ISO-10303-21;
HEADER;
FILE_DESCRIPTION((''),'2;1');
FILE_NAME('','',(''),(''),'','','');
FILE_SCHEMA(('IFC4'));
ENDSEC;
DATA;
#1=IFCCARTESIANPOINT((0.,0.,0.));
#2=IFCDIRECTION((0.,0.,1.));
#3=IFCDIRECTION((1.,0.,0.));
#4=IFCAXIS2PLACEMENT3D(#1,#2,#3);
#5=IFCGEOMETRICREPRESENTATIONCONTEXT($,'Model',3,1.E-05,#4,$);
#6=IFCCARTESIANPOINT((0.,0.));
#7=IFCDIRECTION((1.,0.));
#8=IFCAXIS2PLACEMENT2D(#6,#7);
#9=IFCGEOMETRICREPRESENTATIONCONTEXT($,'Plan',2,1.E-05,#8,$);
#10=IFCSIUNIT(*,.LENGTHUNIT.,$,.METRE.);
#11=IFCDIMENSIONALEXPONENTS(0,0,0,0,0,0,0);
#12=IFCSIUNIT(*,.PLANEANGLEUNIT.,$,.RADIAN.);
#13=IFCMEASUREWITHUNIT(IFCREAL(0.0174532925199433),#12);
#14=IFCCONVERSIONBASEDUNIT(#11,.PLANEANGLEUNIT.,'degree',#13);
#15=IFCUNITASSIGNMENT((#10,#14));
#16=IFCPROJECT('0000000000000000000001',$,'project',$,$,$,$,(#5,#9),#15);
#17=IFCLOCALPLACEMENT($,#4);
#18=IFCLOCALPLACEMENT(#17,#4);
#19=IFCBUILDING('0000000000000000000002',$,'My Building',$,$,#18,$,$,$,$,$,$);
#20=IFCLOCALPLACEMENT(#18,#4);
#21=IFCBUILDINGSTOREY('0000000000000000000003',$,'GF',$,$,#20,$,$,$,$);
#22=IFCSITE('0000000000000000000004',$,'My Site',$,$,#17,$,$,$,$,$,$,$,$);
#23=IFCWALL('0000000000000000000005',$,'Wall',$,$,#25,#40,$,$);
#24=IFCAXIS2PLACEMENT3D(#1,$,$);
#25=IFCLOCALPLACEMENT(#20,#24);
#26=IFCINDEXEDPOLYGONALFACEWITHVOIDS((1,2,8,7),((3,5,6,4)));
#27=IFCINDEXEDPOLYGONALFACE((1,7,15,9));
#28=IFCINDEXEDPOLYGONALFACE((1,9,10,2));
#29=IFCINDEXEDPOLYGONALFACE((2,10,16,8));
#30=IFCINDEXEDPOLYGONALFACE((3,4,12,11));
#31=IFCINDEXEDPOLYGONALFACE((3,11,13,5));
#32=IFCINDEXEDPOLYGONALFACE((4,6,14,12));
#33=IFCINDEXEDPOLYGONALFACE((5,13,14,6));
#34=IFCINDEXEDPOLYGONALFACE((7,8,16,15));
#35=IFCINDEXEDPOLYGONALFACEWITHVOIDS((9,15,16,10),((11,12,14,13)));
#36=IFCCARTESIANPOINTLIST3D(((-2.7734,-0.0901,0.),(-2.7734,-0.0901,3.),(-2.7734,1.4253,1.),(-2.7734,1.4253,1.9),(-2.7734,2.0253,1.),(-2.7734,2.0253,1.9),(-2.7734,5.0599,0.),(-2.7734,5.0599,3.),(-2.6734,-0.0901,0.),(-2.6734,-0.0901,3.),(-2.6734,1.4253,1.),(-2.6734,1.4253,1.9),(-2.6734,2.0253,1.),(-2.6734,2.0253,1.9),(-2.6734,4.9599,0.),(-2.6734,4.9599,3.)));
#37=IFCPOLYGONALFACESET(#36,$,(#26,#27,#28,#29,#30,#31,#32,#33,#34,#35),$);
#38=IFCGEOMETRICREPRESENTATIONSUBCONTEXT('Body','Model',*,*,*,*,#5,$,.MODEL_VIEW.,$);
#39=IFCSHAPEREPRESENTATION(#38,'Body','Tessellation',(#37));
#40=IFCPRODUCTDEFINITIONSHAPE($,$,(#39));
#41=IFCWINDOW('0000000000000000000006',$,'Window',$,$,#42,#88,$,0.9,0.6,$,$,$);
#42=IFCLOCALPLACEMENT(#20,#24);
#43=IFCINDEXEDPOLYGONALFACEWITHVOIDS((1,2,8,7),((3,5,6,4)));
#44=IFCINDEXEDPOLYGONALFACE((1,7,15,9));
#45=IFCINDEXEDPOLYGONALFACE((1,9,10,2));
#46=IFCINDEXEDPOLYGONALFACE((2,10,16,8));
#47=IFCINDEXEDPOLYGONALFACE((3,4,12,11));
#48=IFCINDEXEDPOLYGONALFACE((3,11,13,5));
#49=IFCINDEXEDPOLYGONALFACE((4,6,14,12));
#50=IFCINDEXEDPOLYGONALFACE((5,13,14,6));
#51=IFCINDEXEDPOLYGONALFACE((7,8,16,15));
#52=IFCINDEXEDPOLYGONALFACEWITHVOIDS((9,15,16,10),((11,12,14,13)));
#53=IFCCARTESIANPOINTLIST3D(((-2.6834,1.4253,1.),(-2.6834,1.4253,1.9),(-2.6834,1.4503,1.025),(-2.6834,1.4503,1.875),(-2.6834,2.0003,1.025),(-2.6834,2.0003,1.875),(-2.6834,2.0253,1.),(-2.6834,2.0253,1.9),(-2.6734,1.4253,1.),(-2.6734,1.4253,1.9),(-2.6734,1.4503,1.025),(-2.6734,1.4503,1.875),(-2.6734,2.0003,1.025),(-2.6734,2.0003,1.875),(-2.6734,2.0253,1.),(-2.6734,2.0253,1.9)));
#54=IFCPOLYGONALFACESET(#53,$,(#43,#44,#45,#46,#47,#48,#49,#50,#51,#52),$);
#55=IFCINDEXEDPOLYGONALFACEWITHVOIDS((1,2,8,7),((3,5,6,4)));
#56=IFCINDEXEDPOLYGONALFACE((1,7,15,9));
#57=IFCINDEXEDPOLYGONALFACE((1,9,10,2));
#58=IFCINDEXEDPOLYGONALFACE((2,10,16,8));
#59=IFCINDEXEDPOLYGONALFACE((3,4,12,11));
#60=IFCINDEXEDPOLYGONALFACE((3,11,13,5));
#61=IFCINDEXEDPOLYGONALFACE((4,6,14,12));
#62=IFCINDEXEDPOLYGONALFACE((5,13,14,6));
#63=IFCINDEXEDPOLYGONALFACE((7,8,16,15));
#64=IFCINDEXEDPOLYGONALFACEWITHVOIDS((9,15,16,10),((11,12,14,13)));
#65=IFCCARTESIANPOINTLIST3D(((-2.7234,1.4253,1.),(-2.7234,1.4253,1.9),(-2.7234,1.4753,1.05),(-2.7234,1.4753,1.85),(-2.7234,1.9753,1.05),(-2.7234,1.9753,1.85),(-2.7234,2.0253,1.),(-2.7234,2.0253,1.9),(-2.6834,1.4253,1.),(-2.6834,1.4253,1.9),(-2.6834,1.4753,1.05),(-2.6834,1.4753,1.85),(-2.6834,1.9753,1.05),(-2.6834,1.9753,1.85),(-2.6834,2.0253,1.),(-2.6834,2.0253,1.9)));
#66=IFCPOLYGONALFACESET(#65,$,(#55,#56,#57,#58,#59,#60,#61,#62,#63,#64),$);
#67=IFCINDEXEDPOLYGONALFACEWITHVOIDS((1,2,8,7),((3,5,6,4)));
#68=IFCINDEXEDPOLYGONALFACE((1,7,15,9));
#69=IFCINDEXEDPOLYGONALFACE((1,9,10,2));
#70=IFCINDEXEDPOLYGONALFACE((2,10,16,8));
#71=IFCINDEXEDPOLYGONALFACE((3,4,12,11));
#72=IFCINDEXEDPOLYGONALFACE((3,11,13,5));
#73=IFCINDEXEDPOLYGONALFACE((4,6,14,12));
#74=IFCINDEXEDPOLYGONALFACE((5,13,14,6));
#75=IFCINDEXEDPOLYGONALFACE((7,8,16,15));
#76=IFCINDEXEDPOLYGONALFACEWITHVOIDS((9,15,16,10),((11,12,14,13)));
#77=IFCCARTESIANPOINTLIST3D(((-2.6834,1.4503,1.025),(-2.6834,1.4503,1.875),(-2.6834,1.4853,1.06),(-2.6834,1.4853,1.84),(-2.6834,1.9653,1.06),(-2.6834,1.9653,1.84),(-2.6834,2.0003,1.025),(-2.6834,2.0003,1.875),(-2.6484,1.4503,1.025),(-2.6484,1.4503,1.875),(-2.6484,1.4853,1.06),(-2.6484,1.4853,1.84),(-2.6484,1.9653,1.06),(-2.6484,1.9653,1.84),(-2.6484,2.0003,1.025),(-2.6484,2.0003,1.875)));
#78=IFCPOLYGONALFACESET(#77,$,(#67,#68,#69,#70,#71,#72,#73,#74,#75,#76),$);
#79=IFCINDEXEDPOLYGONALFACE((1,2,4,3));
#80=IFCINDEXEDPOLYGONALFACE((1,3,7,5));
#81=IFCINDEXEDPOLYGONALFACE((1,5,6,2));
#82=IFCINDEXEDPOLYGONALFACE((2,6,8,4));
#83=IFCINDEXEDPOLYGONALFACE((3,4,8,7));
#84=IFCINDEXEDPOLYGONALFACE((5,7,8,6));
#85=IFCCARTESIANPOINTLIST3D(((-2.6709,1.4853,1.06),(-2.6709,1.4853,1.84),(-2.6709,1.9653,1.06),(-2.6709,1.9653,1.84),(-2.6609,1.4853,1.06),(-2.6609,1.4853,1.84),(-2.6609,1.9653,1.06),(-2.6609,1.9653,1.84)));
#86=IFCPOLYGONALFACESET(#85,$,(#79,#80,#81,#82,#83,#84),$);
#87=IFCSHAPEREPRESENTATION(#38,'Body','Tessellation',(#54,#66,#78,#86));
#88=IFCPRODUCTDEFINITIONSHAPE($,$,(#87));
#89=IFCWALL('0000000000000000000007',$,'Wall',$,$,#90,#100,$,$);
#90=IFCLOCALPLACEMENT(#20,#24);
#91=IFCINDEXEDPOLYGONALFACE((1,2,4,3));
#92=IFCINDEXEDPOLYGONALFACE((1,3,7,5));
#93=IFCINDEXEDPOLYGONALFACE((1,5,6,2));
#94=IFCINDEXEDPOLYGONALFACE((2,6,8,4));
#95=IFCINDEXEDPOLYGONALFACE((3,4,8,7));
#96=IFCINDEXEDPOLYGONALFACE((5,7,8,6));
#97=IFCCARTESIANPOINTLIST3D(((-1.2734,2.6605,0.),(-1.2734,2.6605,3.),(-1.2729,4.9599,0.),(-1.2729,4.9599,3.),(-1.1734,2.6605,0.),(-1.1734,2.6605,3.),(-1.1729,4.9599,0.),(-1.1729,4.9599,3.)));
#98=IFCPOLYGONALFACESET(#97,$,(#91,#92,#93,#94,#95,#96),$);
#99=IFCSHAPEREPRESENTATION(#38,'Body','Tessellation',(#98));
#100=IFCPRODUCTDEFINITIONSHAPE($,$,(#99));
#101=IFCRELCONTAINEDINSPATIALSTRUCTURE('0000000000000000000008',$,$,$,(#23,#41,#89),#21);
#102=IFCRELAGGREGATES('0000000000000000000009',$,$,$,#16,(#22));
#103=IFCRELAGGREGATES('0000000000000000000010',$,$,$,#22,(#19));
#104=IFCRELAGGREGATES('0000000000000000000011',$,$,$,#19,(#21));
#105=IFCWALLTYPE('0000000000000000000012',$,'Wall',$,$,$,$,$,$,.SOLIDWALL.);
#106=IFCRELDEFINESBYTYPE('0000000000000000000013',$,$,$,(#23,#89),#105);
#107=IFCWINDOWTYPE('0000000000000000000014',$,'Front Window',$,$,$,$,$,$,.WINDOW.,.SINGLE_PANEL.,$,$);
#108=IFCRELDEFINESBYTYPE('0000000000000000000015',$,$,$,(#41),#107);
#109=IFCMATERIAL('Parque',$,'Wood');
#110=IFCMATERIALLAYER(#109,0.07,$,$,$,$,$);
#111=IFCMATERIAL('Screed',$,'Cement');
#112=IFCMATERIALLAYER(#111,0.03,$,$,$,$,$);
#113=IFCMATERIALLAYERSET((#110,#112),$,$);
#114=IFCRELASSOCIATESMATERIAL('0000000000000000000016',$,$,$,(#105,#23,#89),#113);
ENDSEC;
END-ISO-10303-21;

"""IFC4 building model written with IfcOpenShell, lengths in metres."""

from ifc_helpers import new_model, entity, si_unit, converted_unit, frame, origin_with_axes, origin_2d_with_axis, place, context, subcontext, project, spatial, line, indexed_curve, outline, extrude, shape, source, transform, mapped, material, layer, layer_set, layer_usage, type_object, type_shapes, element, fill, save


model = new_model("IFC4")

# Units and contexts
model_context = context("Model", 3, precision=1e-05, world=origin_with_axes())
plan_context = context("Plan", 2, precision=1e-05, world=origin_2d_with_axis())
body_context_1 = subcontext(model_context, "Body", "Model", "MODEL_VIEW")
body_context_2 = subcontext(plan_context, "Body", "Plan", "PLAN_VIEW")
ifc_project = project(units=[si_unit("LENGTHUNIT", "METRE"), converted_unit("PLANEANGLEUNIT", "degree", entity("IfcReal", 0.0174532925199433), si_unit("PLANEANGLEUNIT", "RADIAN"), dimensions=[0, 0, 0, 0, 0, 0, 0])], contexts=[model_context, plan_context])

# Site, building, storey
site_placement = place(None, origin_with_axes())
site = spatial("IfcSite", under=ifc_project, at=site_placement, Name="My Site")
building_placement = place(site_placement, origin_with_axes())
building = spatial("IfcBuilding", under=site, at=building_placement, Name="My Building")
storey_placement = place(building_placement, origin_with_axes())
storey = spatial("IfcBuildingStorey", under=building, at=storey_placement, Name="GF")

# Shared definitions
ifc_material_1 = material(Name="Parque", Category="Wood")
ifc_layer_1 = layer(ifc_material_1, 0.07)
ifc_material_2 = material(Name="Screed", Category="Cement")
ifc_layer_2 = layer(ifc_material_2, 0.03)
ifc_layer_set_1 = layer_set([ifc_layer_1, ifc_layer_2])
wall_type = type_object("IfcWallType", Name="Wall", PredefinedType="SOLIDWALL", material=ifc_layer_set_1)

# Wall, opening, window
ifc_layer_usage_1 = layer_usage(ifc_layer_set_1, "AXIS2", "POSITIVE", 0.0)
wall_1_placement = place(storey_placement, frame((-2.7734, 5.0599, 0.0), z_axis=(0.0, 0.0, 1.0), x_axis=(0.0, -1.0, 0.0)))
wall_1 = element("IfcWall", 1, at=wall_1_placement, inside=storey, type_object=wall_type, material=ifc_layer_usage_1, Name="Wall", context=body_context_1, shape_type="SweptSolid", body=[
    extrude(outline(indexed_curve([(0.0, 0.0), (0.1, 0.1), (5.15, 0.1), (5.15, 0.0)], segments=[line(1, 2, 3, 4, 1)])), origin_with_axes(), (0.0, 0.0, 1.0), 3.0),
])
shared_shape_1 = source(origin_with_axes(), body_context_1, "Body", "SweptSolid", [
    extrude(outline(indexed_curve([(0.0, 0.0), (0.6, 0.0), (0.6, 0.9), (0.0, 0.9)], segments=[line(1, 2, 3, 4, 1)])), frame((0.0, -0.6, 0.0), z_axis=(0.0, -1.0, 0.0), x_axis=(1.0, 0.0, 0.0)), (0.0, 0.0, -1.0), 1.2),
])
opening_1_placement = place(wall_1_placement, frame((3.0346, 0.0, 1.0), z_axis=(0.0, 0.0, 1.0), x_axis=(1.0, 0.0, 0.0)))
opening_1 = element("IfcOpeningElement", 2, at=opening_1_placement, cuts=wall_1, PredefinedType="OPENING", context=body_context_1, shape_type="MappedRepresentation", body=[
    mapped(shared_shape_1, transform((0.0, 0.0, 0.0), x_axis=(1.0, 0.0, 0.0), y_axis=(0.0, 1.0, 0.0), z_axis=(0.0, 0.0, 1.0), scale=1.0)),
])
window_type_1 = type_object("IfcWindowType", Name="Front Window", PartitioningType="SINGLE_PANEL", PredefinedType="WINDOW")
shared_shape_2 = source(origin_with_axes(), body_context_1, "Body", "SweptSolid", [
    extrude(outline(indexed_curve([(0.0, 0.0), (0.6, 0.0), (0.6, 0.9), (0.0, 0.9)], segments=[line(1, 2, 3, 4, 1)]), holes=[indexed_curve([(0.025, 0.025), (0.575, 0.025), (0.575, 0.875), (0.025, 0.875)], segments=[line(1, 2, 3, 4, 1)])]), frame((0.0, 0.09, 0.0), z_axis=(0.0, -1.0, 0.0), x_axis=(1.0, 0.0, 0.0)), (0.0, 0.0, -1.0), 0.01),
    extrude(outline(indexed_curve([(0.0, 0.0), (0.6, 0.0), (0.6, 0.9), (0.0, 0.9)], segments=[line(1, 2, 3, 4, 1)]), holes=[indexed_curve([(0.05, 0.05), (0.55, 0.05), (0.55, 0.85), (0.05, 0.85)], segments=[line(1, 2, 3, 4, 1)])]), frame((0.0, 0.05, 0.0), z_axis=(0.0, -1.0, 0.0), x_axis=(1.0, 0.0, 0.0)), (0.0, 0.0, -1.0), 0.04),
    extrude(outline(indexed_curve([(0.0, 0.0), (0.55, 0.0), (0.55, 0.85), (0.0, 0.85)], segments=[line(1, 2, 3, 4, 1)]), holes=[indexed_curve([(0.035, 0.035), (0.515, 0.035), (0.515, 0.815), (0.035, 0.815)], segments=[line(1, 2, 3, 4, 1)])]), frame((0.025, 0.09, 0.025), z_axis=(0.0, -1.0, 0.0), x_axis=(1.0, 0.0, 0.0)), (0.0, 0.0, -1.0), 0.035),
    extrude(outline(indexed_curve([(0.035, 0.035), (0.515, 0.035), (0.515, 0.815), (0.035, 0.815)], segments=[line(1, 2, 3, 4, 1)])), frame((0.025, 0.1025, 0.025), z_axis=(0.0, -1.0, 0.0), x_axis=(1.0, 0.0, 0.0)), (0.0, 0.0, -1.0), 0.01),
])
shared_shape_3 = source(origin_with_axes(), body_context_2, "Body", "Curve2D", [
    entity("IfcIndexedPolyCurve", entity("IfcCartesianPointList2D", [[0.05, 0.05], [0.55, 0.05]])),
    entity("IfcIndexedPolyCurve", entity("IfcCartesianPointList2D", [[0.0, 0.1], [0.025, 0.1], [0.025, 0.09], [0.05, 0.09], [0.05, 0.05], [0.0, 0.05]]), [entity("IfcLineIndex", [1, 2, 3, 4, 5, 6, 1])]),
    entity("IfcIndexedPolyCurve", entity("IfcCartesianPointList2D", [[0.6, 0.1], [0.575, 0.1], [0.575, 0.09], [0.55, 0.09], [0.55, 0.05], [0.6, 0.05]]), [entity("IfcLineIndex", [1, 2, 3, 4, 5, 6, 1])]),
    entity("IfcIndexedPolyCurve", entity("IfcCartesianPointList2D", [[0.025, 0.09], [0.06, 0.09], [0.06, 0.125], [0.025, 0.125]]), [entity("IfcLineIndex", [1, 2, 3, 4, 1])]),
    entity("IfcIndexedPolyCurve", entity("IfcCartesianPointList2D", [[0.575, 0.09], [0.54, 0.09], [0.54, 0.125], [0.575, 0.125]]), [entity("IfcLineIndex", [1, 2, 3, 4, 1])]),
    entity("IfcIndexedPolyCurve", entity("IfcCartesianPointList2D", [[0.06, 0.09], [0.54, 0.09]])),
    entity("IfcIndexedPolyCurve", entity("IfcCartesianPointList2D", [[0.06, 0.125], [0.54, 0.125]])),
    entity("IfcIndexedPolyCurve", entity("IfcCartesianPointList2D", [[0.06, 0.1075], [0.54, 0.1075]])),
])
type_shapes(window_type_1, [shared_shape_2, shared_shape_3])
window_1_placement = place(opening_1_placement, frame((0.0, 0.0, 0.0), z_axis=(0.0, 0.0, 1.0), x_axis=(1.0, 0.0, 0.0)))
window_1 = element("IfcWindow", 3, at=window_1_placement, inside=storey, type_object=window_type_1, Name="Window", OverallHeight=0.9, OverallWidth=0.6, shapes=[
    shape(body_context_1, "Body", "MappedRepresentation", [mapped(shared_shape_2, transform((0.0, 0.0, 0.0), x_axis=(1.0, 0.0, 0.0), y_axis=(0.0, 1.0, 0.0), z_axis=(0.0, 0.0, 1.0), scale=1.0))]),
    shape(body_context_2, "Body", "MappedRepresentation", [mapped(shared_shape_3, transform((0.0, 0.0, 0.0), x_axis=(1.0, 0.0, 0.0), y_axis=(0.0, 1.0, 0.0), z_axis=(0.0, 0.0, 1.0), scale=1.0))]),
])
fill(opening_1, window_1)

# Wall
ifc_layer_usage_2 = layer_usage(ifc_layer_set_1, "AXIS2", "POSITIVE", 0.0)
wall_2_placement = place(storey_placement, frame((-1.1734, 2.6605, 0.0), z_axis=(0.0, 0.0, 1.0), x_axis=(0.000197, 1.0, 0.0)))
element("IfcWall", 4, at=wall_2_placement, inside=storey, type_object=wall_type, material=ifc_layer_usage_2, Name="Wall", context=body_context_1, shape_type="SweptSolid", body=[
    extrude(outline(indexed_curve([(0.0, 0.0), (0.0, 0.1), (2.2994, 0.1), (2.2994, 0.0)], segments=[line(1, 2, 3, 4, 1)])), origin_with_axes(), (0.0, 0.0, 1.0), 3.0),
])

save(model, "model.ifc")
